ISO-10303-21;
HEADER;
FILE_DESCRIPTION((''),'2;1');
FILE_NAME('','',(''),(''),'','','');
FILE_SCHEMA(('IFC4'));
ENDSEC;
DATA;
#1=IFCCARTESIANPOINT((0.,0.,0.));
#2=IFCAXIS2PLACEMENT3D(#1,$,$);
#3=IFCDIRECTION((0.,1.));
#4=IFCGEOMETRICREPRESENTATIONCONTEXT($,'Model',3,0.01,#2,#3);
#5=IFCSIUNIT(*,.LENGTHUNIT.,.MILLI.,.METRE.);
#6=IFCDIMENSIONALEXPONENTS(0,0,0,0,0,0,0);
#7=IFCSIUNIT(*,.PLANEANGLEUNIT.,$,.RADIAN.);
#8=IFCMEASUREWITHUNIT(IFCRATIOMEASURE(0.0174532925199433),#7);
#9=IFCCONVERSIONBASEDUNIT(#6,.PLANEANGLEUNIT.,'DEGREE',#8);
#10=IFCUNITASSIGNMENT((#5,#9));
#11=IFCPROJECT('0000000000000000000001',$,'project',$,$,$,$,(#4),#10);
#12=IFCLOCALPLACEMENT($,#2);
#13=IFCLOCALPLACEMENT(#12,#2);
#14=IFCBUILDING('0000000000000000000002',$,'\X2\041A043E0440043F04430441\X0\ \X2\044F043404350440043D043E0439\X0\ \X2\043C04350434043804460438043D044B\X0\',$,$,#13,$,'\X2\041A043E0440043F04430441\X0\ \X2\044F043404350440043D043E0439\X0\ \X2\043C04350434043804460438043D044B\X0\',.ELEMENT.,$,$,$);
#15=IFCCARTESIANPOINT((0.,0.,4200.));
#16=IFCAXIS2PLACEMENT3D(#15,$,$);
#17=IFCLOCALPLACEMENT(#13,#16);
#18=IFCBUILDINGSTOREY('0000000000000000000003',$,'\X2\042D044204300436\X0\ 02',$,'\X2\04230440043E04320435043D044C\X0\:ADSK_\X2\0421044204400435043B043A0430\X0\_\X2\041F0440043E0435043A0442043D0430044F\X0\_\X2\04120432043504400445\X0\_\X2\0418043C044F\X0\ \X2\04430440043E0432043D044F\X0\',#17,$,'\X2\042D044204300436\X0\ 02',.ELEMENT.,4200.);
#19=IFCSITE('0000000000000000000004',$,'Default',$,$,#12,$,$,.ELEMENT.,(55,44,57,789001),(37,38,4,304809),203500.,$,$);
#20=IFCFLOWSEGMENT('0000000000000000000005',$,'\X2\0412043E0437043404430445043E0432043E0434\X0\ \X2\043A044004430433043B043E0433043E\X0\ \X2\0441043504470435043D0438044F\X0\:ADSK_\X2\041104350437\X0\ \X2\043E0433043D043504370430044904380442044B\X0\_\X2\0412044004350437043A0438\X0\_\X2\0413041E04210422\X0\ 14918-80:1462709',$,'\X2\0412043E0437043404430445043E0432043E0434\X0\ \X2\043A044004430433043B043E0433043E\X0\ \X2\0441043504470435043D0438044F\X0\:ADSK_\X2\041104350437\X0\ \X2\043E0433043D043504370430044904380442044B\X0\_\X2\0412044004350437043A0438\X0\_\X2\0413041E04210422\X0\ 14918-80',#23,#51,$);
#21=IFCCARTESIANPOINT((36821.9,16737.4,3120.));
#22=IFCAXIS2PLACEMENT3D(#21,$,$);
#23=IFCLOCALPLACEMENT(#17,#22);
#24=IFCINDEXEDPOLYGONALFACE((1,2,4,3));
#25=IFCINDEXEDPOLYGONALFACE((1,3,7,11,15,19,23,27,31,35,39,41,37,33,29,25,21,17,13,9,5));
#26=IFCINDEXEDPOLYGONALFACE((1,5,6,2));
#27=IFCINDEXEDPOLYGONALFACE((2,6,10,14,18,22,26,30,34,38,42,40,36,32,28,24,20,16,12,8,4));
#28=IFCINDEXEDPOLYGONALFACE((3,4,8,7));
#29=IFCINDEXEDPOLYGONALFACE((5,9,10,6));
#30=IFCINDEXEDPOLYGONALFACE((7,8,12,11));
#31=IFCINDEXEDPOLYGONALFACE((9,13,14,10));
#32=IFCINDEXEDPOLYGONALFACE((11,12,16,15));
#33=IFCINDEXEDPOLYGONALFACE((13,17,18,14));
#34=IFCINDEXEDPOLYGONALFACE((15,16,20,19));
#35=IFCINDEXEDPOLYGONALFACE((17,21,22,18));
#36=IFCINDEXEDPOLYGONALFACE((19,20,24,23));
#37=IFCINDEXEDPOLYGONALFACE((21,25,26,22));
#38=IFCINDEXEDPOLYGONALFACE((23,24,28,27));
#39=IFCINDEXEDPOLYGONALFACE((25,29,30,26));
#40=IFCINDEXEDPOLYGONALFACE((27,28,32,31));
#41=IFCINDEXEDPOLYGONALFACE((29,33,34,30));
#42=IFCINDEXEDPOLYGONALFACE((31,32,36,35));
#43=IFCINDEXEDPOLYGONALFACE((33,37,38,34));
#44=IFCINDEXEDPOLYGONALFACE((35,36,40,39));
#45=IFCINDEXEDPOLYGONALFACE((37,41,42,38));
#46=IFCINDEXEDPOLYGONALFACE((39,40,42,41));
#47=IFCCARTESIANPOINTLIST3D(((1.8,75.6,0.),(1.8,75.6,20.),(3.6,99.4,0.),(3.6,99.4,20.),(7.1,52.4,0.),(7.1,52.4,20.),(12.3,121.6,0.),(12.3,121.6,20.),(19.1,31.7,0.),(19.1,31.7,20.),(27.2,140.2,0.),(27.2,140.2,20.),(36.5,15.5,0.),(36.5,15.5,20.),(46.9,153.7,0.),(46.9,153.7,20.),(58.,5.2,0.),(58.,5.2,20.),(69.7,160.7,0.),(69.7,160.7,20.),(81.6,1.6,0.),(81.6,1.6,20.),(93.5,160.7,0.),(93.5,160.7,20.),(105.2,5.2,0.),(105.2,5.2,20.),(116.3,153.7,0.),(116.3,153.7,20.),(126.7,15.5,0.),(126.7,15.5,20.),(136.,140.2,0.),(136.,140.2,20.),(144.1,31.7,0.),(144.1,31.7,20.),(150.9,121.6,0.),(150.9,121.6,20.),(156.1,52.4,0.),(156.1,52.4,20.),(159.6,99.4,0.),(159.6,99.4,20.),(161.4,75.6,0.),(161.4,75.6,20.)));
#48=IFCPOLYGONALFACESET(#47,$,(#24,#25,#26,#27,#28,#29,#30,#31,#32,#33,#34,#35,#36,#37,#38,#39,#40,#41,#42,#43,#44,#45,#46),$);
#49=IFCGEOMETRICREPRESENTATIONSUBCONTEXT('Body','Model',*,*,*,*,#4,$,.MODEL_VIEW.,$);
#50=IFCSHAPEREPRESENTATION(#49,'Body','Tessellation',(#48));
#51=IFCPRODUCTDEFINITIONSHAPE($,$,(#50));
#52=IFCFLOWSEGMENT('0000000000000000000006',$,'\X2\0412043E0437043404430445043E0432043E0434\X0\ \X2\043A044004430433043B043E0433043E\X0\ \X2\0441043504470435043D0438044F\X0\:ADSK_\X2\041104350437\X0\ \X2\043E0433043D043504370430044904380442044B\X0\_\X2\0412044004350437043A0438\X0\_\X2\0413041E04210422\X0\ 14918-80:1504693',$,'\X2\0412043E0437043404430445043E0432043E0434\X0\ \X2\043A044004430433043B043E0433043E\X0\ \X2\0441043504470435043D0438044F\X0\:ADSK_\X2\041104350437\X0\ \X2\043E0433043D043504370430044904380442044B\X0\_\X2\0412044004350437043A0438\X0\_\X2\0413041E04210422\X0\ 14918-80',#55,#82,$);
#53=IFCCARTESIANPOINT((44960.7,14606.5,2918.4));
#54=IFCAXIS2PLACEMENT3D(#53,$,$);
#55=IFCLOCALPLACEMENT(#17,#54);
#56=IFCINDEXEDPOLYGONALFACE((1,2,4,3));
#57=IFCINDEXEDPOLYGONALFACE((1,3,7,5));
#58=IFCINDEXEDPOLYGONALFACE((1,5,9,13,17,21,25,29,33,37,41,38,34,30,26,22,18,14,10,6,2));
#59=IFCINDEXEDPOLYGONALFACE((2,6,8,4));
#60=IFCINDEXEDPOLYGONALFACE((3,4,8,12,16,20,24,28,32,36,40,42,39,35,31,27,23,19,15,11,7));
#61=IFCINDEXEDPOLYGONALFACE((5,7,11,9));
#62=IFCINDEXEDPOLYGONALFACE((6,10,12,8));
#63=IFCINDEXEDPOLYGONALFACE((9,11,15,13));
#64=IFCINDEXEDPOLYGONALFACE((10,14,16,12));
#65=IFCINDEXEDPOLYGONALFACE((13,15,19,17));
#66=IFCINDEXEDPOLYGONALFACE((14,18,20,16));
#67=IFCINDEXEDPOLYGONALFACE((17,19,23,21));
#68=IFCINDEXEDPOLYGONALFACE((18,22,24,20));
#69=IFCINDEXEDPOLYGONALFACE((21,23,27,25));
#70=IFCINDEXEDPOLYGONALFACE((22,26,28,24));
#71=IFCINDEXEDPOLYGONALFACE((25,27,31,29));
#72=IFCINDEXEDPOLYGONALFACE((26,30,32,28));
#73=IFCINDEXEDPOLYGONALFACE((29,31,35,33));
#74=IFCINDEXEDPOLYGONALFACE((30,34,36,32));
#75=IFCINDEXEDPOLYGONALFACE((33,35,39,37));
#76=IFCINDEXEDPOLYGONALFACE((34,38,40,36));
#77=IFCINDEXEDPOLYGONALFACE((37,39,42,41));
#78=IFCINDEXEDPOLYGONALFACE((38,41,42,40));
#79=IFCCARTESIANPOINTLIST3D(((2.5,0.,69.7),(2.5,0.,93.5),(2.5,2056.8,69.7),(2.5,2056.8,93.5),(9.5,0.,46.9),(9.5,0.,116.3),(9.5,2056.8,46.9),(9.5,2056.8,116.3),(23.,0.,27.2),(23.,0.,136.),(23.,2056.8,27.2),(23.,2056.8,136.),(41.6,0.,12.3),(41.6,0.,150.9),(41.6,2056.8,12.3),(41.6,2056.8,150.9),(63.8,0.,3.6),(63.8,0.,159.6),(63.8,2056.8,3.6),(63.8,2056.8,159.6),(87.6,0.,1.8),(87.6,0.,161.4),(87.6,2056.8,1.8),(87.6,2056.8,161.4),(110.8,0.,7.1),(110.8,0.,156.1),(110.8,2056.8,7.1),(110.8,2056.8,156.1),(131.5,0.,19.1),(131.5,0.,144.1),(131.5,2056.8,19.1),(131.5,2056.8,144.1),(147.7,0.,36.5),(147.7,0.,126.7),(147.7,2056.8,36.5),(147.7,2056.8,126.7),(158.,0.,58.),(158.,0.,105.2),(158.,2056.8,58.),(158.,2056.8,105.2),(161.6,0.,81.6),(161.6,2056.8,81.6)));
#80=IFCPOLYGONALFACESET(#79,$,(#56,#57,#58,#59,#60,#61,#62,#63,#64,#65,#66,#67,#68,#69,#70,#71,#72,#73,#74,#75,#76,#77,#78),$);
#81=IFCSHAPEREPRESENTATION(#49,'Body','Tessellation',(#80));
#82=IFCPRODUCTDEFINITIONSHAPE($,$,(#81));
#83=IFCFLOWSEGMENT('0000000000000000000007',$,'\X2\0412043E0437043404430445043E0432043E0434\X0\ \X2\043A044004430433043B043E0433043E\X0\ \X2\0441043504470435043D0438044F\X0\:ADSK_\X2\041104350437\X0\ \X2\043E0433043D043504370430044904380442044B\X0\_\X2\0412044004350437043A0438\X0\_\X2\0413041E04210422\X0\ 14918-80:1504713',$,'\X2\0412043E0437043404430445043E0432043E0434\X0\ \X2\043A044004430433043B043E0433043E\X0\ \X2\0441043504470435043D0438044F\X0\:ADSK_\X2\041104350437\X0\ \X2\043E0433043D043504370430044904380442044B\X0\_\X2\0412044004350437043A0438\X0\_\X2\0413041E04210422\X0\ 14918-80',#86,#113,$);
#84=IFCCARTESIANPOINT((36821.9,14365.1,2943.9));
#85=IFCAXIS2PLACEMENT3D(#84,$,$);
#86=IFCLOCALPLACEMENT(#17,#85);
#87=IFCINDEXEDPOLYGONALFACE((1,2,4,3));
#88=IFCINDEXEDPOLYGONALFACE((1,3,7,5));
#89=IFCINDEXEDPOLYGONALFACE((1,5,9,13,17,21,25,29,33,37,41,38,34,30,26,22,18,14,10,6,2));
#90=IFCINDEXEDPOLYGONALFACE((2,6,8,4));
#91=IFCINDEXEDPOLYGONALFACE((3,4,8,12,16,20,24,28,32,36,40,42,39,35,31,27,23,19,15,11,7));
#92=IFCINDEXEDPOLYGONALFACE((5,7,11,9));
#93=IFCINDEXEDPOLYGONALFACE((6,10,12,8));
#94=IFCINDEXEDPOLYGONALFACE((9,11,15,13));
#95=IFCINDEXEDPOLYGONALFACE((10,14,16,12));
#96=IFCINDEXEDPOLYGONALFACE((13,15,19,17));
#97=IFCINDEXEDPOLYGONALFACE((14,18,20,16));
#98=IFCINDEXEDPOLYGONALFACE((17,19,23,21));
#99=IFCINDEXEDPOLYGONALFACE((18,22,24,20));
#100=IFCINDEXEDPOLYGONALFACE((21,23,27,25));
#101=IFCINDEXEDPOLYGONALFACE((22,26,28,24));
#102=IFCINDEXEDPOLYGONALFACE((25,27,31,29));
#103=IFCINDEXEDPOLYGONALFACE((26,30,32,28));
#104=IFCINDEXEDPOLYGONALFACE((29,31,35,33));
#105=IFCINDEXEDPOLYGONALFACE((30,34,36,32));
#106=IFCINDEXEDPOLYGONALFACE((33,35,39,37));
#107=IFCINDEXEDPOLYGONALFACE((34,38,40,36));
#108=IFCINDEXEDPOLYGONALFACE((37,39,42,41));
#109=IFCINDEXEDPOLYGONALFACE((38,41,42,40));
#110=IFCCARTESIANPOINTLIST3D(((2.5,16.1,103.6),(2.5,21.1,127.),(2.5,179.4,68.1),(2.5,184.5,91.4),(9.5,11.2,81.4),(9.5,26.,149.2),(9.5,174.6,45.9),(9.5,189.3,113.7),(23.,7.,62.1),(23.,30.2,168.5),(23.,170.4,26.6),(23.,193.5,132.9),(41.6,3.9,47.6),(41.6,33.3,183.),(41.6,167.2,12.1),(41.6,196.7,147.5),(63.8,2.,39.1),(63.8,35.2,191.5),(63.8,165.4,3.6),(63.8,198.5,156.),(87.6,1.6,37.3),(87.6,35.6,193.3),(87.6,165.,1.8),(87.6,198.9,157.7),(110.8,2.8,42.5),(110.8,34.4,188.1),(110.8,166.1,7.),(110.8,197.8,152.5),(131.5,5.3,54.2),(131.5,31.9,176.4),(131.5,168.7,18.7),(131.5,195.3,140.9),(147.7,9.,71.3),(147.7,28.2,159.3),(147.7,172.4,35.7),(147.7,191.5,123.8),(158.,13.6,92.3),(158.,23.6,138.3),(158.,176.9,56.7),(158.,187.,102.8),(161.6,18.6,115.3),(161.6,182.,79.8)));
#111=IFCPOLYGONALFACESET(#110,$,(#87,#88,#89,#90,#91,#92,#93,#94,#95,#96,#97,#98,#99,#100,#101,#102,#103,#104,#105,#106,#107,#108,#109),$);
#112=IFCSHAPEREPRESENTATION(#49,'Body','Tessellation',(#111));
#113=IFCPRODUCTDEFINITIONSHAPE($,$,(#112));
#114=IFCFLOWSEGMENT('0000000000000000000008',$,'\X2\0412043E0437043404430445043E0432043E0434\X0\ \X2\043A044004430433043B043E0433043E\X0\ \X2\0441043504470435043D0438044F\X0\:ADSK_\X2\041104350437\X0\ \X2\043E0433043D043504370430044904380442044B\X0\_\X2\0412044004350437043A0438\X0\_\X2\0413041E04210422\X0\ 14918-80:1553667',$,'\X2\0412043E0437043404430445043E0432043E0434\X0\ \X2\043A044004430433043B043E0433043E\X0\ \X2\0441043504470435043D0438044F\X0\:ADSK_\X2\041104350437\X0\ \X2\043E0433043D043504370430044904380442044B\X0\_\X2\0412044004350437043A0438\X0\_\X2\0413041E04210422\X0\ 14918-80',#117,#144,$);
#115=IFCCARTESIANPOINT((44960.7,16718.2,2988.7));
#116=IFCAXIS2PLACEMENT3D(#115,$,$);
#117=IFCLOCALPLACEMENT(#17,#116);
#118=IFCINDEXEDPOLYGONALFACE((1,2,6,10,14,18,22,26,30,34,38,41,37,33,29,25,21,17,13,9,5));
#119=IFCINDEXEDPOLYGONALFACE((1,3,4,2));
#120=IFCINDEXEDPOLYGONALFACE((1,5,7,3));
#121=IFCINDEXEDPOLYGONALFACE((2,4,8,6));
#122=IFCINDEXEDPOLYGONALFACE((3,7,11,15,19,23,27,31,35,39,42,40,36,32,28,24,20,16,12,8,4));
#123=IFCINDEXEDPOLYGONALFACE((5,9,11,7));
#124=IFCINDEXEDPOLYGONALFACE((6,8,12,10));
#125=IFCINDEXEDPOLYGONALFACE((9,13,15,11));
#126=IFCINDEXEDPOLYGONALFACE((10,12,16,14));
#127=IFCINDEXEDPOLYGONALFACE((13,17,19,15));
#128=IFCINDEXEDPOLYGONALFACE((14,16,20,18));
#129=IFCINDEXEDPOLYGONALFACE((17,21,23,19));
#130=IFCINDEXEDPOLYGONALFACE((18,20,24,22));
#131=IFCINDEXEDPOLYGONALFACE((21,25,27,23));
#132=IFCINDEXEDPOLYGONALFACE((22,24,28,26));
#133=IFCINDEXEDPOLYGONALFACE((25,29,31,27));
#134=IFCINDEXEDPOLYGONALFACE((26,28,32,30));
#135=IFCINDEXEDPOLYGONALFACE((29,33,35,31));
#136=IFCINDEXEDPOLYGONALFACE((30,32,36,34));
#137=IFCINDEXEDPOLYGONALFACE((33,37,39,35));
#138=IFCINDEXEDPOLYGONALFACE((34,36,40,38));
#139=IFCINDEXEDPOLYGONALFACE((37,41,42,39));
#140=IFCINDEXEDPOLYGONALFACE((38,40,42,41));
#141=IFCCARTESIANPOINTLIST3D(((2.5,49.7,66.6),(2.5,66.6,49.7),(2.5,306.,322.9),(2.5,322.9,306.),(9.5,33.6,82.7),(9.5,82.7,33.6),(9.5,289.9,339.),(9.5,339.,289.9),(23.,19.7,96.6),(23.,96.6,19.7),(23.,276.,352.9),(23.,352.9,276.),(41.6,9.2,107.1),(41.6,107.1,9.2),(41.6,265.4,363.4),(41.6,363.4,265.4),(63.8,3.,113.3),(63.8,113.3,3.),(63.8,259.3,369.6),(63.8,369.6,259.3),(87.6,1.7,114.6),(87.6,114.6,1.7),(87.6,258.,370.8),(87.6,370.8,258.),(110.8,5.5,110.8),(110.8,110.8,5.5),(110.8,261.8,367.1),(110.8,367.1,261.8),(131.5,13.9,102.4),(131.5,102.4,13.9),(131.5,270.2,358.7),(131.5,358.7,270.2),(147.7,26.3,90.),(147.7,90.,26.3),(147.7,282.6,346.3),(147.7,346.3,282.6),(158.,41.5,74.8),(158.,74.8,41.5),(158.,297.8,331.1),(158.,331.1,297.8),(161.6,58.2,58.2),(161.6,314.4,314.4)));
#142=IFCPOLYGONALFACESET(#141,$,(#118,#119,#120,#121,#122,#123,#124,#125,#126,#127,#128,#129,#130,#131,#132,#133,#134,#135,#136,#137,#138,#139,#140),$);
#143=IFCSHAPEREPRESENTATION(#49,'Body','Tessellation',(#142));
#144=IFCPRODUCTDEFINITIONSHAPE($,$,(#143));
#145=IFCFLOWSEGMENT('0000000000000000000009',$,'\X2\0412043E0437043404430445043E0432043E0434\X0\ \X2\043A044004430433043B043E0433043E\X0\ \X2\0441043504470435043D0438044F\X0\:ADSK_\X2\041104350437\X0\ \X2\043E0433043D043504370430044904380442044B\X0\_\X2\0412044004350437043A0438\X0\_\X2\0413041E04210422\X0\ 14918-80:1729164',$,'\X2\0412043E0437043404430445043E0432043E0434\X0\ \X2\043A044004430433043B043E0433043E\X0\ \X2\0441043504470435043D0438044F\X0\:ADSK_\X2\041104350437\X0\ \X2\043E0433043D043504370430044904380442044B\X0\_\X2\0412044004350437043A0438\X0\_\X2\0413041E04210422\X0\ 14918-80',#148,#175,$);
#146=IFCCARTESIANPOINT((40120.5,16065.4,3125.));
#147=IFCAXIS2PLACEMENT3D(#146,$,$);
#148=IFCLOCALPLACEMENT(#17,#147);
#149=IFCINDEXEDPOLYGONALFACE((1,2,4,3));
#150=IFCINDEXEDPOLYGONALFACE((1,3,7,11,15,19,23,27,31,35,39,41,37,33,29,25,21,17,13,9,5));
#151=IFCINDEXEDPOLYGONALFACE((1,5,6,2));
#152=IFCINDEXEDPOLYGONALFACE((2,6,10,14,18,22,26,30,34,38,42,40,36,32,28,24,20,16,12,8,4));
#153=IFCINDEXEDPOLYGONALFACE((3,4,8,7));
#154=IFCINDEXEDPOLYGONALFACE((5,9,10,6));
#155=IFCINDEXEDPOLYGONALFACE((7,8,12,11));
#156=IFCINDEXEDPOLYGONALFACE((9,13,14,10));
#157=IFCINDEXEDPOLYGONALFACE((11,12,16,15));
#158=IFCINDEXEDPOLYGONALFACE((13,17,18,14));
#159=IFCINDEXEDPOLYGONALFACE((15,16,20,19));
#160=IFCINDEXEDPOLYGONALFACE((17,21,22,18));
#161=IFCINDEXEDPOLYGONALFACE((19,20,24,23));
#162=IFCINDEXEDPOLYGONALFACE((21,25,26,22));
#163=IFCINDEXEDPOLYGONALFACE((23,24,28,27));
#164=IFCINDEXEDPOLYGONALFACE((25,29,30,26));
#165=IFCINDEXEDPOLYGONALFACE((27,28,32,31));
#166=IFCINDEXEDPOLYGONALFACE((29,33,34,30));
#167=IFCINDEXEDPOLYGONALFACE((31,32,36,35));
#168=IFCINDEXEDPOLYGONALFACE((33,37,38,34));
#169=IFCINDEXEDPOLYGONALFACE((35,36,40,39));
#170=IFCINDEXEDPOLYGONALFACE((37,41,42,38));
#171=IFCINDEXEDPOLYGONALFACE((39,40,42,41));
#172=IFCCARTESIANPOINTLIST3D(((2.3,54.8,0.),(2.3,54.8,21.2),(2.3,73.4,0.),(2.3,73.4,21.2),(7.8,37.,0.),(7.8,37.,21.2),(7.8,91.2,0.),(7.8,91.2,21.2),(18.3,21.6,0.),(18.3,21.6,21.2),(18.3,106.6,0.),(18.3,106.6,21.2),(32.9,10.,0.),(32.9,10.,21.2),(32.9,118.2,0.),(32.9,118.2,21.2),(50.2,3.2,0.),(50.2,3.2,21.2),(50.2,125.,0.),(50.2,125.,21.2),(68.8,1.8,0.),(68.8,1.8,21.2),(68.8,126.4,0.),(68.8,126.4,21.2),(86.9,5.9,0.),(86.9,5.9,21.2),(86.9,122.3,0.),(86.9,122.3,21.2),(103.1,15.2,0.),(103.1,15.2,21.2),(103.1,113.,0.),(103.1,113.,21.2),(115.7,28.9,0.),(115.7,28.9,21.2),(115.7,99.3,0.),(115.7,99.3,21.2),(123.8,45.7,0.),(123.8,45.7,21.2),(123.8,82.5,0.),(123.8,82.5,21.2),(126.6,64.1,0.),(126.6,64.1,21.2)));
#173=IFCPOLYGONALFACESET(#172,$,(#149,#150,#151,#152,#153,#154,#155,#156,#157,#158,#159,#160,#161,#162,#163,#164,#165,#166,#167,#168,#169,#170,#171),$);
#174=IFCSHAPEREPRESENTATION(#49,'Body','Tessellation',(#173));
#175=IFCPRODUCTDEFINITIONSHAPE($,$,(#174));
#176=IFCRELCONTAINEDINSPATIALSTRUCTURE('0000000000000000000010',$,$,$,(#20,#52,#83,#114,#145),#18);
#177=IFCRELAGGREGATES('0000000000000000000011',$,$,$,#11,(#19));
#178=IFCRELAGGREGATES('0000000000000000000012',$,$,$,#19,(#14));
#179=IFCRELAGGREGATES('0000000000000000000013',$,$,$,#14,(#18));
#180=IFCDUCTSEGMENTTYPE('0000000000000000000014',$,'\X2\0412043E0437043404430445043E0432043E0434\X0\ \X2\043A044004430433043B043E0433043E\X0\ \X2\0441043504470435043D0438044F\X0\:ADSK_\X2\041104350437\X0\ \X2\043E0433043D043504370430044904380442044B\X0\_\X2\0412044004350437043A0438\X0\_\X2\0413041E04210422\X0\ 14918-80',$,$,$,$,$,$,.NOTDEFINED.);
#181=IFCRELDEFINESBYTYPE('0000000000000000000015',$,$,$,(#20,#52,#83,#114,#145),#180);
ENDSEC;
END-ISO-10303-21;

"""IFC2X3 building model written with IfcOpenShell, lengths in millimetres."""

from ifc_helpers import new_model, entity, si_unit, converted_unit, direction, frame, origin, origin_2d_with_axis, place, context, subcontext, project, spatial, circle, extrude, type_object, element, save


model = new_model("IFC2X3")

# Units and contexts
model_context = context("Model", 3, precision=0.01, world=origin(), true_north=direction((0.0, 1.0)))
body_context = subcontext(model_context, "Body", "Model", "MODEL_VIEW")
ifc_project = project(units=[si_unit("LENGTHUNIT", "METRE", prefix="MILLI"), converted_unit("PLANEANGLEUNIT", "DEGREE", entity("IfcRatioMeasure", 0.0174532925199433), si_unit("PLANEANGLEUNIT", "RADIAN"), dimensions=[0, 0, 0, 0, 0, 0, 0])], contexts=[model_context])

# Site, building, storey
site_placement = place(None, origin())
site = spatial("IfcSite", under=ifc_project, at=site_placement, Name="Default", CompositionType="ELEMENT", RefLatitude=(55, 44, 57, 789001), RefLongitude=(37, 38, 4, 304809), RefElevation=203500.0)
building_placement = place(site_placement, origin())
building = spatial("IfcBuilding", under=site, at=building_placement, Name="Корпус ядерной медицины", LongName="Корпус ядерной медицины", CompositionType="ELEMENT")
storey_placement = place(building_placement, frame((0.0, 0.0, 4200.0)))
storey = spatial("IfcBuildingStorey", under=building, at=storey_placement, Name="Этаж 02", ObjectType="Уровень:ADSK_Стрелка_Проектная_Вверх_Имя уровня", LongName="Этаж 02", CompositionType="ELEMENT", Elevation=4200.0)

# Flow segments
duct_segment_type = type_object("IfcDuctSegmentType", Name="Воздуховод круглого сечения:ADSK_Без огнезащиты_Врезки_ГОСТ 14918-80", PredefinedType="NOTDEFINED")
flow_segment_1_placement = place(storey_placement, frame((36821.9, 16737.4, 3120.0)))
element("IfcFlowSegment", 1, at=flow_segment_1_placement, inside=storey, type_object=duct_segment_type, Name="Воздуховод круглого сечения:ADSK_Без огнезащиты_Врезки_ГОСТ 14918-80:1462709", ObjectType="Воздуховод круглого сечения:ADSK_Без огнезащиты_Врезки_ГОСТ 14918-80", context=body_context, shape_type="SweptSolid", body=[
    extrude(circle(Radius=80.0, at=origin_2d_with_axis()), frame((81.6, 81.6, 0.0), z_axis=(0.0, 0.0, 1.0), x_axis=(0.0, -1.0, 0.0)), (0.0, 0.0, 1.0), 20.0),
])
flow_segment_2_placement = place(storey_placement, frame((44960.7, 14606.5, 2918.4)))
element("IfcFlowSegment", 2, at=flow_segment_2_placement, inside=storey, type_object=duct_segment_type, Name="Воздуховод круглого сечения:ADSK_Без огнезащиты_Врезки_ГОСТ 14918-80:1504693", ObjectType="Воздуховод круглого сечения:ADSK_Без огнезащиты_Врезки_ГОСТ 14918-80", context=body_context, shape_type="SweptSolid", body=[
    extrude(circle(Radius=80.0, at=origin_2d_with_axis()), frame((81.6, 0.0, 81.6), z_axis=(0.0, 1.0, 0.0), x_axis=(1.0, 0.0, 0.0)), (0.0, 0.0, 1.0), 2056.8),
])
flow_segment_3_placement = place(storey_placement, frame((36821.9, 14365.1, 2943.9)))
element("IfcFlowSegment", 3, at=flow_segment_3_placement, inside=storey, type_object=duct_segment_type, Name="Воздуховод круглого сечения:ADSK_Без огнезащиты_Врезки_ГОСТ 14918-80:1504713", ObjectType="Воздуховод круглого сечения:ADSK_Без огнезащиты_Врезки_ГОСТ 14918-80", context=body_context, shape_type="SweptSolid", body=[
    extrude(circle(Radius=80.0, at=origin_2d_with_axis()), frame((81.6, 182.0, 79.8), z_axis=(0.0, -0.977156, 0.212522), x_axis=(1.0, 0.0, 0.0)), (0.0, 0.0, 1.0), 167.2),
])
flow_segment_4_placement = place(storey_placement, frame((44960.7, 16718.2, 2988.7)))
element("IfcFlowSegment", 4, at=flow_segment_4_placement, inside=storey, type_object=duct_segment_type, Name="Воздуховод круглого сечения:ADSK_Без огнезащиты_Врезки_ГОСТ 14918-80:1553667", ObjectType="Воздуховод круглого сечения:ADSK_Без огнезащиты_Врезки_ГОСТ 14918-80", context=body_context, shape_type="SweptSolid", body=[
    extrude(circle(Radius=80.0, at=origin_2d_with_axis()), frame((81.6, 58.2, 58.2), z_axis=(0.0, 0.707107, 0.707107), x_axis=(1.0, 0.0, 0.0)), (0.0, 0.0, 1.0), 362.4),
])
flow_segment_5_placement = place(storey_placement, frame((40120.5, 16065.4, 3125.0)))
element("IfcFlowSegment", 5, at=flow_segment_5_placement, inside=storey, type_object=duct_segment_type, Name="Воздуховод круглого сечения:ADSK_Без огнезащиты_Врезки_ГОСТ 14918-80:1729164", ObjectType="Воздуховод круглого сечения:ADSK_Без огнезащиты_Врезки_ГОСТ 14918-80", context=body_context, shape_type="SweptSolid", body=[
    extrude(circle(Radius=62.5, at=origin_2d_with_axis()), frame((64.1, 64.1, 0.0)), (0.0, 0.0, 1.0), 21.2),
])

save(model, "model.ifc")
